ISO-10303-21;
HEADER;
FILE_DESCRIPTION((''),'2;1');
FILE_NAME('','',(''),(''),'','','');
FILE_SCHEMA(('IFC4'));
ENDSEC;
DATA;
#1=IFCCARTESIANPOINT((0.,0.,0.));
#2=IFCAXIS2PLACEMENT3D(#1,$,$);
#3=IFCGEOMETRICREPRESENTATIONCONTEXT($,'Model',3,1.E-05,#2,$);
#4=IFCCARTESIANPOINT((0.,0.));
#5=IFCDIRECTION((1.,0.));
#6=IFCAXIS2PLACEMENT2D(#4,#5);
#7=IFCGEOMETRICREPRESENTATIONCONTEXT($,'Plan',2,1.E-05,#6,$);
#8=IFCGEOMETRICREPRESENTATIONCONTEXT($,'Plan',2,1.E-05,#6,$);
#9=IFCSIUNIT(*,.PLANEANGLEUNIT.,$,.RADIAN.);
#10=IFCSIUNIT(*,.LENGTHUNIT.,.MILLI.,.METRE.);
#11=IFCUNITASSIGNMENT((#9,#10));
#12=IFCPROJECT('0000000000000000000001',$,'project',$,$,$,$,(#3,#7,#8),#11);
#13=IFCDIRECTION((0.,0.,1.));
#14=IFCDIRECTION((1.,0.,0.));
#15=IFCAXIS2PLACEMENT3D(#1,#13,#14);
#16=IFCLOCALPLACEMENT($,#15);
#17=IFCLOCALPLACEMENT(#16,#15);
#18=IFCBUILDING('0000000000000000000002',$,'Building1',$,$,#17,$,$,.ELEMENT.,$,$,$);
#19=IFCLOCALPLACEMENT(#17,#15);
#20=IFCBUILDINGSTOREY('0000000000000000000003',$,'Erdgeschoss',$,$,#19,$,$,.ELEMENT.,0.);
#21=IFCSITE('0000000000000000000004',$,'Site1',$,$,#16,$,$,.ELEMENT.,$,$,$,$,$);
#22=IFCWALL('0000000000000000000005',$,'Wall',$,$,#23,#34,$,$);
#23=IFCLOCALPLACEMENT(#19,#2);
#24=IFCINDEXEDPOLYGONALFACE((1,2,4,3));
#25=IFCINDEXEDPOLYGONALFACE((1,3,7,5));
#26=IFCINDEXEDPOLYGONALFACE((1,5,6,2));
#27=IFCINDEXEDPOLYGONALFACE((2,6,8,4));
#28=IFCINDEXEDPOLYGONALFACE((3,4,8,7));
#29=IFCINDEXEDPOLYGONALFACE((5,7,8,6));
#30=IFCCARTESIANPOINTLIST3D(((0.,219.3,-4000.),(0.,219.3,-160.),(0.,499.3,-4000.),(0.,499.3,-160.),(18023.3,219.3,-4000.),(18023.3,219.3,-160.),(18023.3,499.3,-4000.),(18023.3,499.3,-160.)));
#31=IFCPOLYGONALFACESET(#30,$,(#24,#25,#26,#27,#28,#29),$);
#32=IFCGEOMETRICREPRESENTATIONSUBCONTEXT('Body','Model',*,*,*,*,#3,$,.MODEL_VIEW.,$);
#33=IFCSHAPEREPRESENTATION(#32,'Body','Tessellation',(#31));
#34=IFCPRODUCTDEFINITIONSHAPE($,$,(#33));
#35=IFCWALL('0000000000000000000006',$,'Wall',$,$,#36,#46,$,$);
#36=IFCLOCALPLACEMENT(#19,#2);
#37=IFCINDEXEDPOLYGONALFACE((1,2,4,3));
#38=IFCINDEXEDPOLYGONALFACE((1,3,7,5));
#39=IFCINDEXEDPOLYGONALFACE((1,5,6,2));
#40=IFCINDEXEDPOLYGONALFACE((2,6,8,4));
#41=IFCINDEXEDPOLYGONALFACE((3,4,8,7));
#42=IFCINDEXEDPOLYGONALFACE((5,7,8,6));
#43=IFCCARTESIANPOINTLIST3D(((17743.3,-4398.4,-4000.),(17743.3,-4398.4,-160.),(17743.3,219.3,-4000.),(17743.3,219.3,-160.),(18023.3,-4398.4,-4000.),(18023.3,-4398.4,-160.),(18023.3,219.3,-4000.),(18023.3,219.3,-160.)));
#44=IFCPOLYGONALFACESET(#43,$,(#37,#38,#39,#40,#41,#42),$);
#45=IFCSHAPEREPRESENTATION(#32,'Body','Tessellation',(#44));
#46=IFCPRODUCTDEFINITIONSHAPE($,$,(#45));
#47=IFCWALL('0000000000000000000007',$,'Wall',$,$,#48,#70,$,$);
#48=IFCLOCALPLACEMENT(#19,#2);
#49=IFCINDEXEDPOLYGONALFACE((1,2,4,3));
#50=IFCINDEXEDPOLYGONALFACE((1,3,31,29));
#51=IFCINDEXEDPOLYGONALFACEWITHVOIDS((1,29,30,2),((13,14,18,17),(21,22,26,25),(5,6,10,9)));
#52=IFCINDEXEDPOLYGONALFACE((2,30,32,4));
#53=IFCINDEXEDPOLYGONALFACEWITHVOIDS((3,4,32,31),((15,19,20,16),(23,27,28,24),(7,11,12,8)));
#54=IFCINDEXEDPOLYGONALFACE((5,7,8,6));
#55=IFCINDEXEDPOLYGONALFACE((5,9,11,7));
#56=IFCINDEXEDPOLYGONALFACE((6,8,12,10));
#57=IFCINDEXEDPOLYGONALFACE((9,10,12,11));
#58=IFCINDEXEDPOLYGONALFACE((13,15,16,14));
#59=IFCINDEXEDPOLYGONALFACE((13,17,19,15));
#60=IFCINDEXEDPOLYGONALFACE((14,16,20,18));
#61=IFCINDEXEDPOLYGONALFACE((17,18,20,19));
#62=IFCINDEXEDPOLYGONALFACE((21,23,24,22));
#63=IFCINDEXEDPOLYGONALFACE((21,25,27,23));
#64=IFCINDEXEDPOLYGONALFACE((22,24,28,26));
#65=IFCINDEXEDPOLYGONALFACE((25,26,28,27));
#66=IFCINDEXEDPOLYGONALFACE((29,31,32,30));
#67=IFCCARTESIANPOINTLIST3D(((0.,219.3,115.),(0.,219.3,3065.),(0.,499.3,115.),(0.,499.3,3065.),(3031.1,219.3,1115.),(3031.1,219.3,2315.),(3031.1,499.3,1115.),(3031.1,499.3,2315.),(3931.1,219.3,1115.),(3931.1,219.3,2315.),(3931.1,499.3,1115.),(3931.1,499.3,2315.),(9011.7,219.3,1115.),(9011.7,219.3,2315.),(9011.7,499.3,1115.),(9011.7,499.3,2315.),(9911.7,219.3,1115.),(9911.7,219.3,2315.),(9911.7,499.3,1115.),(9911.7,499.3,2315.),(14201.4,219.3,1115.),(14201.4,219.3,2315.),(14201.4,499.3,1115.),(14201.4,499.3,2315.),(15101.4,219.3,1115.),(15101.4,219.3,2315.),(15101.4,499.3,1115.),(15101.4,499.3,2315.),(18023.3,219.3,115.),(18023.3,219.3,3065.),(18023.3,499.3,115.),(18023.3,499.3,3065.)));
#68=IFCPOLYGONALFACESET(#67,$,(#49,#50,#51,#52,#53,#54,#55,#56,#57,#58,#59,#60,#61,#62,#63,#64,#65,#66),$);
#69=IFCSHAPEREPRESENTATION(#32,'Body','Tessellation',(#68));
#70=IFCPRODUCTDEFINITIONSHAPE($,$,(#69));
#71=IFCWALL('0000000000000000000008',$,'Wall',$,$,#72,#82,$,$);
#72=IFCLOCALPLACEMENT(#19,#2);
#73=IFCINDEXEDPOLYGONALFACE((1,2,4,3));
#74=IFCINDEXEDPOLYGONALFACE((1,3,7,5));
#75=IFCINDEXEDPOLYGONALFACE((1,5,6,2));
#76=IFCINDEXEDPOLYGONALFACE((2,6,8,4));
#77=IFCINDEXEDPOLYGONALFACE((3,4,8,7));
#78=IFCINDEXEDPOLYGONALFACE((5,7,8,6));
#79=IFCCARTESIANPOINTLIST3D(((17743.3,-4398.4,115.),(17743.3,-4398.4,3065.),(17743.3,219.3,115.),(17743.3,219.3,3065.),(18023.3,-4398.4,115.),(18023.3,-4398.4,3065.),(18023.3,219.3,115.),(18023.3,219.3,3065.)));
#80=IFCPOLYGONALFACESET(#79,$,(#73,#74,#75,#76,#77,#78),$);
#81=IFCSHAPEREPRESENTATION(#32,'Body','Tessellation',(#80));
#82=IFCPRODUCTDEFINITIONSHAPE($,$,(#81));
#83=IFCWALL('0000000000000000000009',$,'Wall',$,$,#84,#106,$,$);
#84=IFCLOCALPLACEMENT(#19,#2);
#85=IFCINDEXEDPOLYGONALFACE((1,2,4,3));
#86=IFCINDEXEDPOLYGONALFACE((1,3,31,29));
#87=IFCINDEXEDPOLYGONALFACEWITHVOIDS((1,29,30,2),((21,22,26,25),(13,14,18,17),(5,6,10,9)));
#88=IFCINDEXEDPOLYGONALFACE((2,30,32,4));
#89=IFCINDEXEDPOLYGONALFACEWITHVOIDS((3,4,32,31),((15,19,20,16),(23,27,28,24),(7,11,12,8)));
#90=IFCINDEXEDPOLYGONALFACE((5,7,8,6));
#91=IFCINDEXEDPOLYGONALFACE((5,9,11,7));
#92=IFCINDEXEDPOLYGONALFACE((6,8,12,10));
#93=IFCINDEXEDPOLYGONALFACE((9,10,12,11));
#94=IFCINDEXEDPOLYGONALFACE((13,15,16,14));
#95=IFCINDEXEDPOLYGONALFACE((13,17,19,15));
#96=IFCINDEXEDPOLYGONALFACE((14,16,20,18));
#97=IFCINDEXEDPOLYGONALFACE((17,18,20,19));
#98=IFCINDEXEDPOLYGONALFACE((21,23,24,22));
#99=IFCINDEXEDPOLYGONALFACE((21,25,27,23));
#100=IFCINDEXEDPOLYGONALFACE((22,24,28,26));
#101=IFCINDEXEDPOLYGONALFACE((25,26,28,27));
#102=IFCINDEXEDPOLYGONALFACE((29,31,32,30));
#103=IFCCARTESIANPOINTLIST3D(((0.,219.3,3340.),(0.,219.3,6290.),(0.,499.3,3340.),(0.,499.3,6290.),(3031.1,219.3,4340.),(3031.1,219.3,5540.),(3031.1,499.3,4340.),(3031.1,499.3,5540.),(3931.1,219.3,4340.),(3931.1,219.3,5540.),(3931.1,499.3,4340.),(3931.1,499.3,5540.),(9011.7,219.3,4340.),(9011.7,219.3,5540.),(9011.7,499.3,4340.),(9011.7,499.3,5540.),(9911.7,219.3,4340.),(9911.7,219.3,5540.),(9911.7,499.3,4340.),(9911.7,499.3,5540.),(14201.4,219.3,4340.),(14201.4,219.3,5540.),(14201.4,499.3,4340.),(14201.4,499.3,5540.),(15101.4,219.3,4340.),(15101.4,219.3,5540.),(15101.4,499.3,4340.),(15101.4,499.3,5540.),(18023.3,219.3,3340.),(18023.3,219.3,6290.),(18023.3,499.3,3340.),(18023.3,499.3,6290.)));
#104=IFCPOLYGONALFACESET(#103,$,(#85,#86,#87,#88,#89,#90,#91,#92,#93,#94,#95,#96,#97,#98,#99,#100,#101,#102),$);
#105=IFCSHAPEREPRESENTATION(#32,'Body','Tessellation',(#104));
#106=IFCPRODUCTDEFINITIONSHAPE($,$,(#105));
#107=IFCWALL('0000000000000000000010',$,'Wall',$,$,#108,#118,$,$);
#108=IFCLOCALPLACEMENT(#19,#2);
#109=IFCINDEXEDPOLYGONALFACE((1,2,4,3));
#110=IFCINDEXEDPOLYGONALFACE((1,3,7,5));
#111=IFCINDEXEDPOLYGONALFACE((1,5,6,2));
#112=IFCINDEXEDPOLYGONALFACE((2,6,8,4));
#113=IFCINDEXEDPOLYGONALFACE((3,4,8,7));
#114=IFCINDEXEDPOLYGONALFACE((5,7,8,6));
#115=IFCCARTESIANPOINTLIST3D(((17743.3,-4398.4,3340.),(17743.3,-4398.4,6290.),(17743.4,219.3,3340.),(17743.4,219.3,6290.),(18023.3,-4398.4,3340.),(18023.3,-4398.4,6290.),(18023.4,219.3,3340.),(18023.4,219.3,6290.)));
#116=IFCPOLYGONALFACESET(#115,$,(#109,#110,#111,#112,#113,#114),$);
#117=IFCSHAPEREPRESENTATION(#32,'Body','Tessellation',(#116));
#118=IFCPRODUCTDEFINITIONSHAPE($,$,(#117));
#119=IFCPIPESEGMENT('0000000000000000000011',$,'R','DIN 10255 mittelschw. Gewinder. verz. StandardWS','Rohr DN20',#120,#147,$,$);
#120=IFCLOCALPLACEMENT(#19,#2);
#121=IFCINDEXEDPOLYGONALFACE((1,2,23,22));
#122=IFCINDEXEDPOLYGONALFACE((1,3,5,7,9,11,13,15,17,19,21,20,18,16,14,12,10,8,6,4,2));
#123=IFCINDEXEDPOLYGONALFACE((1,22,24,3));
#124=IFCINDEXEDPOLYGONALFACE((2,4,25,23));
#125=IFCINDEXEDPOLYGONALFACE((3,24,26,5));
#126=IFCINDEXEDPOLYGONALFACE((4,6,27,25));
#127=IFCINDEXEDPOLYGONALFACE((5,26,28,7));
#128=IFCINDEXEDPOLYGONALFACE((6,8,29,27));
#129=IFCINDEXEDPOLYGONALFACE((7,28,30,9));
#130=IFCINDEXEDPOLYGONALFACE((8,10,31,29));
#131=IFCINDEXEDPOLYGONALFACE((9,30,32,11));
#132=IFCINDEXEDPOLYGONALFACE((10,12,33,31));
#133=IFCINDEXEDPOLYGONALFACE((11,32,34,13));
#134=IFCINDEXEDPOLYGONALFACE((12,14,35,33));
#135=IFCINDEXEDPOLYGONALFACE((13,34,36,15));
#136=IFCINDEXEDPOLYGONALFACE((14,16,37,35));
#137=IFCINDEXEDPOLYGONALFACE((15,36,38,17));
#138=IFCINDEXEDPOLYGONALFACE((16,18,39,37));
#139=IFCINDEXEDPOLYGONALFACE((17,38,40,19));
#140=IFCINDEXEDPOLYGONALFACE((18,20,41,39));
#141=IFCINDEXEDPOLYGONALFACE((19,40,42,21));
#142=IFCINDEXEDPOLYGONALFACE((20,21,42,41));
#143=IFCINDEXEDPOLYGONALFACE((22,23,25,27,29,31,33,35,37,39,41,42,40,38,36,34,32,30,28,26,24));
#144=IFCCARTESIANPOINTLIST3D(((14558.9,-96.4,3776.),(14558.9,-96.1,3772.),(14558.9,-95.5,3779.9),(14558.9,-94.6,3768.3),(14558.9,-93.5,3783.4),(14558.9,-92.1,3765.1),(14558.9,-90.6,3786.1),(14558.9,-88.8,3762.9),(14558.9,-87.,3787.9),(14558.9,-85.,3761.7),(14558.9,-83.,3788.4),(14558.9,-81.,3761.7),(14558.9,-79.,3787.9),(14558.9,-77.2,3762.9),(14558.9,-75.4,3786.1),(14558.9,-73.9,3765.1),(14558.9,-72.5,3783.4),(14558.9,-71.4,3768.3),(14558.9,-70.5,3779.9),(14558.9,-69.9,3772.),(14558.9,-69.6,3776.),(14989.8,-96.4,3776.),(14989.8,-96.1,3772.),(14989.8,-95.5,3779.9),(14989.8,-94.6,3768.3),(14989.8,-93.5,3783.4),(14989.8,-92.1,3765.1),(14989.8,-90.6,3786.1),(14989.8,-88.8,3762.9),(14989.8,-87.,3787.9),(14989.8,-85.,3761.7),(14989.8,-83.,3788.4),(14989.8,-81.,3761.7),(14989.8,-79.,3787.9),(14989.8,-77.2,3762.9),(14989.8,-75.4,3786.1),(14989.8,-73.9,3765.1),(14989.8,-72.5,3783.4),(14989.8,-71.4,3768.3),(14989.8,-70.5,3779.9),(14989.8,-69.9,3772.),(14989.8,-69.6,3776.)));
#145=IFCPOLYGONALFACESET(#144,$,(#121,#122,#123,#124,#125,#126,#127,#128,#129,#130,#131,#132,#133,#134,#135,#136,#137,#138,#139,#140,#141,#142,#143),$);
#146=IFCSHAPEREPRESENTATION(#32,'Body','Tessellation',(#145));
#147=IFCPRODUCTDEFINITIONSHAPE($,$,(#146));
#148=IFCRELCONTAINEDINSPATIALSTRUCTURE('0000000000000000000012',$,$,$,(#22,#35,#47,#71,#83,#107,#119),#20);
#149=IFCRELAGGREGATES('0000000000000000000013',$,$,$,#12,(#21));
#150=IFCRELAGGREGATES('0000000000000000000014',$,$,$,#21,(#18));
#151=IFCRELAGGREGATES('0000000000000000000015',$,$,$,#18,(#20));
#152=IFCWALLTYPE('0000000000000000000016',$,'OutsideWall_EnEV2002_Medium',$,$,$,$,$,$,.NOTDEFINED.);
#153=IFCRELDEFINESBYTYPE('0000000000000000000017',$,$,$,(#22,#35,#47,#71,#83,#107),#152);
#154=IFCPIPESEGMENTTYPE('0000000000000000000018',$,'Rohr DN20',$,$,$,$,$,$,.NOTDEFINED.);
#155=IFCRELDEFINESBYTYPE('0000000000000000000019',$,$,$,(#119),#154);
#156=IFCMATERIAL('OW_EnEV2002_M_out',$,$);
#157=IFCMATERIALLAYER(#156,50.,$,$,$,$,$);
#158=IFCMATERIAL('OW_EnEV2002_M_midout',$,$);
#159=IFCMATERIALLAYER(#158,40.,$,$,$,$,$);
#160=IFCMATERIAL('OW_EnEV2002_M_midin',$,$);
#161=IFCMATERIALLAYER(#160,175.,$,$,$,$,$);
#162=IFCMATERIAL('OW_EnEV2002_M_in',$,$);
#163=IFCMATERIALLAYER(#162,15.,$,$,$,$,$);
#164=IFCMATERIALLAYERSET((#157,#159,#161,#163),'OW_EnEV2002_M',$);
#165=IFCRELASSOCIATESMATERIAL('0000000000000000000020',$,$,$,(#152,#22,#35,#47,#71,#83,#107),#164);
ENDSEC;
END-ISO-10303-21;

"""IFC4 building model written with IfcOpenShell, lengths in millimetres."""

from ifc_helpers import new_model, si_unit, frame, origin, origin_with_axes, origin_2d_with_axis, place, context, subcontext, project, spatial, line, indexed_curve, circle, outline, extrude, source, transform, mapped, material, layer, layer_set, layer_usage, type_object, element, save


model = new_model("IFC4")

# Units and contexts
model_context = context("Model", 3, precision=1e-05, world=origin())
plan_context_1 = context("Plan", 2, precision=1e-05, world=origin_2d_with_axis())
plan_context_2 = context("Plan", 2, precision=1e-05, world=origin_2d_with_axis())
body_context = subcontext(model_context, "Body", "Model", "MODEL_VIEW")
ifc_project = project(units=[si_unit("PLANEANGLEUNIT", "RADIAN"), si_unit("LENGTHUNIT", "METRE", prefix="MILLI")], contexts=[model_context, plan_context_1, plan_context_2])

# Site, building, storey
site_placement = place(None, origin_with_axes())
site = spatial("IfcSite", under=ifc_project, at=site_placement, Name="Site1", CompositionType="ELEMENT")
building_placement = place(site_placement, origin_with_axes())
building = spatial("IfcBuilding", under=site, at=building_placement, Name="Building1", CompositionType="ELEMENT")
storey_placement = place(building_placement, origin_with_axes())
storey = spatial("IfcBuildingStorey", under=building, at=storey_placement, Name="Erdgeschoss", CompositionType="ELEMENT", Elevation=0.0)

# Walls
ifc_material_1 = material(Name="OW_EnEV2002_M_out")
ifc_layer_1 = layer(ifc_material_1, 50.0)
ifc_material_2 = material(Name="OW_EnEV2002_M_midout")
ifc_layer_2 = layer(ifc_material_2, 40.0)
ifc_material_3 = material(Name="OW_EnEV2002_M_midin")
ifc_layer_3 = layer(ifc_material_3, 175.0)
ifc_material_4 = material(Name="OW_EnEV2002_M_in")
ifc_layer_4 = layer(ifc_material_4, 15.0)
ifc_layer_set = layer_set([ifc_layer_1, ifc_layer_2, ifc_layer_3, ifc_layer_4], Name="OW_EnEV2002_M")
ifc_layer_usage_1 = layer_usage(ifc_layer_set, "AXIS2", "POSITIVE", 0.0)
wall_type = type_object("IfcWallType", Name="OutsideWall_EnEV2002_Medium", PredefinedType="NOTDEFINED", material=ifc_layer_set)
wall_1_placement = place(storey_placement, frame((18023.3, 499.3, -4000.0), z_axis=(0.0, 0.0, 1.0), x_axis=(-1.0, 0.0, 0.0)))
element("IfcWall", 1, at=wall_1_placement, inside=storey, type_object=wall_type, material=ifc_layer_usage_1, Name="Wall", context=body_context, shape_type="SweptSolid", body=[
    extrude(outline(indexed_curve([(0.0, 0.0), (0.0, 280.0), (18023.3, 280.0), (18023.3, 0.0), (0.0, 0.0)], self_intersect=False)), origin_with_axes(), (0.0, 0.0, 1.0), 3840.0),
])
ifc_layer_usage_2 = layer_usage(ifc_layer_set, "AXIS2", "POSITIVE", 0.0)
wall_2_placement = place(storey_placement, frame((18023.3, -4398.4, -4000.0), z_axis=(0.0, 0.0, 1.0), x_axis=(0.0, 1.0, 0.0)))
element("IfcWall", 2, at=wall_2_placement, inside=storey, type_object=wall_type, material=ifc_layer_usage_2, Name="Wall", context=body_context, shape_type="SweptSolid", body=[
    extrude(outline(indexed_curve([(0.0, 0.0), (0.0, 280.0), (4617.6, 280.0), (4617.6, 0.0), (0.0, 0.0)], self_intersect=False)), origin_with_axes(), (0.0, 0.0, 1.0), 3840.0),
])

# Wall, openings
ifc_layer_usage_3 = layer_usage(ifc_layer_set, "AXIS2", "POSITIVE", 0.0)
wall_3_placement = place(storey_placement, frame((18023.3, 499.3, 115.0), z_axis=(0.0, 0.0, 1.0), x_axis=(-1.0, 0.0, 0.0)))
wall_3 = element("IfcWall", 3, at=wall_3_placement, inside=storey, type_object=wall_type, material=ifc_layer_usage_3, Name="Wall", context=body_context, shape_type="SweptSolid", body=[
    extrude(outline(indexed_curve([(0.0, 0.0), (0.0, 280.0), (18023.3, 280.0), (18023.3, 0.0), (0.0, 0.0)], self_intersect=False)), origin_with_axes(), (0.0, 0.0, 1.0), 2950.0),
])
shared_shape_1 = source(origin_with_axes(), body_context, "Body", "SweptSolid", [
    extrude(outline(indexed_curve([(0.0, 0.0), (900.0, 0.0), (900.0, 1200.0), (0.0, 1200.0)], segments=[line(1, 2, 3, 4, 1)])), frame((0.0, -600.0, 0.0), z_axis=(0.0, -1.0, 0.0), x_axis=(1.0, 0.0, 0.0)), (0.0, 0.0, -1.0), 1200.0),
])
opening_1_placement = place(wall_3_placement, frame((2921.9, 0.0, 1000.0), z_axis=(0.0, 0.0, 1.0), x_axis=(1.0, 0.0, 0.0)))
element("IfcOpeningElement", 4, at=opening_1_placement, cuts=wall_3, PredefinedType="OPENING", context=body_context, shape_type="MappedRepresentation", body=[
    mapped(shared_shape_1, transform((0.0, 0.0, 0.0), x_axis=(1.0, 0.0, 0.0), y_axis=(0.0, 1.0, 0.0), z_axis=(0.0, 0.0, 1.0), scale=1.0)),
])
opening_2_placement = place(wall_3_placement, frame((8111.7, 0.0, 1000.0), z_axis=(0.0, 0.0, 1.0), x_axis=(1.0, 0.0, 0.0)))
element("IfcOpeningElement", 5, at=opening_2_placement, cuts=wall_3, PredefinedType="OPENING", context=body_context, shape_type="MappedRepresentation", body=[
    mapped(shared_shape_1, transform((0.0, 0.0, 0.0), x_axis=(1.0, 0.0, 0.0), y_axis=(0.0, 1.0, 0.0), z_axis=(0.0, 0.0, 1.0), scale=1.0)),
])
opening_3_placement = place(wall_3_placement, frame((14092.2, 0.0, 1000.0), z_axis=(0.0, 0.0, 1.0), x_axis=(1.0, 0.0, 0.0)))
element("IfcOpeningElement", 6, at=opening_3_placement, cuts=wall_3, PredefinedType="OPENING", context=body_context, shape_type="MappedRepresentation", body=[
    mapped(shared_shape_1, transform((0.0, 0.0, 0.0), x_axis=(1.0, 0.0, 0.0), y_axis=(0.0, 1.0, 0.0), z_axis=(0.0, 0.0, 1.0), scale=1.0)),
])

# Wall
ifc_layer_usage_4 = layer_usage(ifc_layer_set, "AXIS2", "POSITIVE", 0.0)
wall_4_placement = place(storey_placement, frame((18023.3, -4398.4, 115.0), z_axis=(0.0, 0.0, 1.0), x_axis=(0.0, 1.0, 0.0)))
element("IfcWall", 7, at=wall_4_placement, inside=storey, type_object=wall_type, material=ifc_layer_usage_4, Name="Wall", context=body_context, shape_type="SweptSolid", body=[
    extrude(outline(indexed_curve([(0.0, 0.0), (0.0, 280.0), (4617.6, 280.0), (4617.6, 0.0), (0.0, 0.0)], self_intersect=False)), origin_with_axes(), (0.0, 0.0, 1.0), 2950.0),
])

# Wall, openings
ifc_layer_usage_5 = layer_usage(ifc_layer_set, "AXIS2", "POSITIVE", 0.0)
wall_5_placement = place(storey_placement, frame((18023.3, 499.3, 3340.0), z_axis=(0.0, 0.0, 1.0), x_axis=(-1.0, 0.0, 0.0)))
wall_5 = element("IfcWall", 8, at=wall_5_placement, inside=storey, type_object=wall_type, material=ifc_layer_usage_5, Name="Wall", context=body_context, shape_type="SweptSolid", body=[
    extrude(outline(indexed_curve([(0.0, 0.0), (0.0, 280.0), (18023.3, 280.0), (18023.3, 0.0), (0.0, 0.0)], self_intersect=False)), origin_with_axes(), (0.0, 0.0, 1.0), 2950.0),
])
opening_4_placement = place(wall_5_placement, frame((14092.2, 0.0, 1000.0), z_axis=(0.0, 0.0, 1.0), x_axis=(1.0, 0.0, 0.0)))
element("IfcOpeningElement", 9, at=opening_4_placement, cuts=wall_5, PredefinedType="OPENING", context=body_context, shape_type="MappedRepresentation", body=[
    mapped(shared_shape_1, transform((0.0, 0.0, 0.0), x_axis=(1.0, 0.0, 0.0), y_axis=(0.0, 1.0, 0.0), z_axis=(0.0, 0.0, 1.0), scale=1.0)),
])
opening_5_placement = place(wall_5_placement, frame((8111.7, 0.0, 1000.0), z_axis=(0.0, 0.0, 1.0), x_axis=(1.0, 0.0, 0.0)))
element("IfcOpeningElement", 10, at=opening_5_placement, cuts=wall_5, PredefinedType="OPENING", context=body_context, shape_type="MappedRepresentation", body=[
    mapped(shared_shape_1, transform((0.0, 0.0, 0.0), x_axis=(1.0, 0.0, 0.0), y_axis=(0.0, 1.0, 0.0), z_axis=(0.0, 0.0, 1.0), scale=1.0)),
])
opening_6_placement = place(wall_5_placement, frame((2921.9, 0.0, 1000.0), z_axis=(0.0, 0.0, 1.0), x_axis=(1.0, 0.0, 0.0)))
element("IfcOpeningElement", 11, at=opening_6_placement, cuts=wall_5, PredefinedType="OPENING", context=body_context, shape_type="MappedRepresentation", body=[
    mapped(shared_shape_1, transform((0.0, 0.0, 0.0), x_axis=(1.0, 0.0, 0.0), y_axis=(0.0, 1.0, 0.0), z_axis=(0.0, 0.0, 1.0), scale=1.0)),
])

# Wall
ifc_layer_usage_6 = layer_usage(ifc_layer_set, "AXIS2", "POSITIVE", 0.0)
wall_6_placement = place(storey_placement, frame((18023.3, -4398.4, 3340.0), z_axis=(0.0, 0.0, 1.0), x_axis=(0.000001, 1.0, 0.0)))
element("IfcWall", 12, at=wall_6_placement, inside=storey, type_object=wall_type, material=ifc_layer_usage_6, Name="Wall", context=body_context, shape_type="SweptSolid", body=[
    extrude(outline(indexed_curve([(0.0, 0.0), (0.0, 280.0), (4617.6, 280.0), (4617.6, 0.0), (0.0, 0.0)], self_intersect=False)), origin_with_axes(), (0.0, 0.0, 1.0), 2950.0),
])

# Pipe segment
pipe_segment_type_1 = type_object("IfcPipeSegmentType", Name="Rohr DN20", PredefinedType="NOTDEFINED")
pipe_segment_1_placement = place(storey_placement, frame((14774.4, -83.2, 3775.0), z_axis=(0.0, 0.0, 1.0), x_axis=(1.0, 0.0, 0.0)))
element("IfcPipeSegment", 13, at=pipe_segment_1_placement, inside=storey, type_object=pipe_segment_type_1, Name="R", Description="DIN 10255 mittelschw. Gewinder. verz. StandardWS", ObjectType="Rohr DN20", context=body_context, shape_type="SolidModel", body=[
    extrude(circle(Radius=13.4, at=origin_2d_with_axis()), frame((215.5, 0.2, 0.0), z_axis=(-1.0, 0.0, 0.0), x_axis=(0.0, 0.0, 1.0)), (0.0, 0.0, 1.0), 430.9),
])

save(model, "model.ifc")
